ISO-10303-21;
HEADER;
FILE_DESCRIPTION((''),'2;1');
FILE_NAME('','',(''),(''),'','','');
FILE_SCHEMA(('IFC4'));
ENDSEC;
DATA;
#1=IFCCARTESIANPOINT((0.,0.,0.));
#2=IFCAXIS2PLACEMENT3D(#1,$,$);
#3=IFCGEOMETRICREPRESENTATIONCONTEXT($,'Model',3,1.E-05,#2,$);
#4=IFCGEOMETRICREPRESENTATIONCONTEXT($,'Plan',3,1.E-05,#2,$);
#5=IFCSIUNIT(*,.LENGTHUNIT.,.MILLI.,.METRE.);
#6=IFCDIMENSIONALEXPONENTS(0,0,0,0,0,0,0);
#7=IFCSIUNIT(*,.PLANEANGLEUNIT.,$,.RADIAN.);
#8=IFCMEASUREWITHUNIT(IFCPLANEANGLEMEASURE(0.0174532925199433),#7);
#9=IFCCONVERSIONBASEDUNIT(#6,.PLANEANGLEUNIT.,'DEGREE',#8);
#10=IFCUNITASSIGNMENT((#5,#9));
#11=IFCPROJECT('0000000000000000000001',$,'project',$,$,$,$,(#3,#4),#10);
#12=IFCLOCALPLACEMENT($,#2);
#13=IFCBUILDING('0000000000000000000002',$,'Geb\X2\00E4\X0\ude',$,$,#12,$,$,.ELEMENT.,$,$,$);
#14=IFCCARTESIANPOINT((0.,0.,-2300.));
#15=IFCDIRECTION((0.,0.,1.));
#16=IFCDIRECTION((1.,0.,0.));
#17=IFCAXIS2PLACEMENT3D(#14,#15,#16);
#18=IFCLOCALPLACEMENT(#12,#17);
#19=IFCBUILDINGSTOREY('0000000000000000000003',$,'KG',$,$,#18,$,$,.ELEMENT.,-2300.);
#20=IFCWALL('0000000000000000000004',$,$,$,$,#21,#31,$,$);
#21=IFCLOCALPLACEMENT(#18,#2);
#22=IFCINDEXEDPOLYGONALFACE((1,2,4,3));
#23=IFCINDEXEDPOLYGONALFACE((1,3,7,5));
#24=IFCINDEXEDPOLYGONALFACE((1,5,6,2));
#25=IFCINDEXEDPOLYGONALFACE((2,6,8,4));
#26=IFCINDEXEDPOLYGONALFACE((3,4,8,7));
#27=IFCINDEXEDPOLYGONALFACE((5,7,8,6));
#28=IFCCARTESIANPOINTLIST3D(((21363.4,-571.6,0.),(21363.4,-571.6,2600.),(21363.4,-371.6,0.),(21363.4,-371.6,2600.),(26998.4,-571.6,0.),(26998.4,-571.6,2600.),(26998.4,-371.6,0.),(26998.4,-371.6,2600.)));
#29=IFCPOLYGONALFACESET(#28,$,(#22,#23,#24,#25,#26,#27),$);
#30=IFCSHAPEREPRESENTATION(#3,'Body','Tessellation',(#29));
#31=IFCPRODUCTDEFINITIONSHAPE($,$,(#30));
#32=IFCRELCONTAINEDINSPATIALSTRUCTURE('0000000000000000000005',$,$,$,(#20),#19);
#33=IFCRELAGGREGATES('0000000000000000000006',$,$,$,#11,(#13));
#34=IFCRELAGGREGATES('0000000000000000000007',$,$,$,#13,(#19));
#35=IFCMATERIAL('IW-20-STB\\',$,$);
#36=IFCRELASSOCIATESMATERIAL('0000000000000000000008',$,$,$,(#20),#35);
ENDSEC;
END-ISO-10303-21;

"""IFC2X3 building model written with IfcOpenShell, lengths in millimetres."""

from ifc_helpers import new_model, entity, si_unit, converted_unit, frame, origin, place, context, project, spatial, polyline, outline, extrude, material, element, save


model = new_model("IFC2X3")

# Units and contexts
model_context = context("Model", 3, precision=1e-05, world=origin())
plan_context = context("Plan", 3, precision=1e-05, world=origin())
ifc_project = project(units=[si_unit("LENGTHUNIT", "METRE", prefix="MILLI"), converted_unit("PLANEANGLEUNIT", "DEGREE", entity("IfcPlaneAngleMeasure", 0.0174532925199433), si_unit("PLANEANGLEUNIT", "RADIAN"), dimensions=[0, 0, 0, 0, 0, 0, 0])], contexts=[model_context, plan_context])

# Building, storey
building_placement = place(None, origin())
building = spatial("IfcBuilding", under=ifc_project, at=building_placement, Name="Gebäude", CompositionType="ELEMENT")
storey_placement = place(building_placement, frame((0.0, 0.0, -2300.0), z_axis=(0.0, 0.0, 1.0), x_axis=(1.0, 0.0, 0.0)))
storey = spatial("IfcBuildingStorey", under=building, at=storey_placement, Name="KG", CompositionType="ELEMENT", Elevation=-2300.0)

# Wall
ifc_material_1 = material(Name="IW-20-STB\\")
wall_1_placement = place(storey_placement, frame((33488.4, -371.6, 0.0), z_axis=(0.0, 0.0, 1.0), x_axis=(-1.0, 0.0, 0.0)))
element("IfcWall", 1, at=wall_1_placement, inside=storey, material=ifc_material_1, context=model_context, shape_type="SweptSolid", body=[
    extrude(outline(polyline([(0.0, 0.0), (5635.0, 0.0), (5635.0, 200.0), (0.0, 200.0), (0.0, 0.0)])), frame((6490.0, 0.0, 0.0), z_axis=(0.0, 0.0, 1.0), x_axis=(1.0, 0.0, 0.0)), (0.0, 0.0, 1.0), 2600.0),
])

save(model, "model.ifc")
